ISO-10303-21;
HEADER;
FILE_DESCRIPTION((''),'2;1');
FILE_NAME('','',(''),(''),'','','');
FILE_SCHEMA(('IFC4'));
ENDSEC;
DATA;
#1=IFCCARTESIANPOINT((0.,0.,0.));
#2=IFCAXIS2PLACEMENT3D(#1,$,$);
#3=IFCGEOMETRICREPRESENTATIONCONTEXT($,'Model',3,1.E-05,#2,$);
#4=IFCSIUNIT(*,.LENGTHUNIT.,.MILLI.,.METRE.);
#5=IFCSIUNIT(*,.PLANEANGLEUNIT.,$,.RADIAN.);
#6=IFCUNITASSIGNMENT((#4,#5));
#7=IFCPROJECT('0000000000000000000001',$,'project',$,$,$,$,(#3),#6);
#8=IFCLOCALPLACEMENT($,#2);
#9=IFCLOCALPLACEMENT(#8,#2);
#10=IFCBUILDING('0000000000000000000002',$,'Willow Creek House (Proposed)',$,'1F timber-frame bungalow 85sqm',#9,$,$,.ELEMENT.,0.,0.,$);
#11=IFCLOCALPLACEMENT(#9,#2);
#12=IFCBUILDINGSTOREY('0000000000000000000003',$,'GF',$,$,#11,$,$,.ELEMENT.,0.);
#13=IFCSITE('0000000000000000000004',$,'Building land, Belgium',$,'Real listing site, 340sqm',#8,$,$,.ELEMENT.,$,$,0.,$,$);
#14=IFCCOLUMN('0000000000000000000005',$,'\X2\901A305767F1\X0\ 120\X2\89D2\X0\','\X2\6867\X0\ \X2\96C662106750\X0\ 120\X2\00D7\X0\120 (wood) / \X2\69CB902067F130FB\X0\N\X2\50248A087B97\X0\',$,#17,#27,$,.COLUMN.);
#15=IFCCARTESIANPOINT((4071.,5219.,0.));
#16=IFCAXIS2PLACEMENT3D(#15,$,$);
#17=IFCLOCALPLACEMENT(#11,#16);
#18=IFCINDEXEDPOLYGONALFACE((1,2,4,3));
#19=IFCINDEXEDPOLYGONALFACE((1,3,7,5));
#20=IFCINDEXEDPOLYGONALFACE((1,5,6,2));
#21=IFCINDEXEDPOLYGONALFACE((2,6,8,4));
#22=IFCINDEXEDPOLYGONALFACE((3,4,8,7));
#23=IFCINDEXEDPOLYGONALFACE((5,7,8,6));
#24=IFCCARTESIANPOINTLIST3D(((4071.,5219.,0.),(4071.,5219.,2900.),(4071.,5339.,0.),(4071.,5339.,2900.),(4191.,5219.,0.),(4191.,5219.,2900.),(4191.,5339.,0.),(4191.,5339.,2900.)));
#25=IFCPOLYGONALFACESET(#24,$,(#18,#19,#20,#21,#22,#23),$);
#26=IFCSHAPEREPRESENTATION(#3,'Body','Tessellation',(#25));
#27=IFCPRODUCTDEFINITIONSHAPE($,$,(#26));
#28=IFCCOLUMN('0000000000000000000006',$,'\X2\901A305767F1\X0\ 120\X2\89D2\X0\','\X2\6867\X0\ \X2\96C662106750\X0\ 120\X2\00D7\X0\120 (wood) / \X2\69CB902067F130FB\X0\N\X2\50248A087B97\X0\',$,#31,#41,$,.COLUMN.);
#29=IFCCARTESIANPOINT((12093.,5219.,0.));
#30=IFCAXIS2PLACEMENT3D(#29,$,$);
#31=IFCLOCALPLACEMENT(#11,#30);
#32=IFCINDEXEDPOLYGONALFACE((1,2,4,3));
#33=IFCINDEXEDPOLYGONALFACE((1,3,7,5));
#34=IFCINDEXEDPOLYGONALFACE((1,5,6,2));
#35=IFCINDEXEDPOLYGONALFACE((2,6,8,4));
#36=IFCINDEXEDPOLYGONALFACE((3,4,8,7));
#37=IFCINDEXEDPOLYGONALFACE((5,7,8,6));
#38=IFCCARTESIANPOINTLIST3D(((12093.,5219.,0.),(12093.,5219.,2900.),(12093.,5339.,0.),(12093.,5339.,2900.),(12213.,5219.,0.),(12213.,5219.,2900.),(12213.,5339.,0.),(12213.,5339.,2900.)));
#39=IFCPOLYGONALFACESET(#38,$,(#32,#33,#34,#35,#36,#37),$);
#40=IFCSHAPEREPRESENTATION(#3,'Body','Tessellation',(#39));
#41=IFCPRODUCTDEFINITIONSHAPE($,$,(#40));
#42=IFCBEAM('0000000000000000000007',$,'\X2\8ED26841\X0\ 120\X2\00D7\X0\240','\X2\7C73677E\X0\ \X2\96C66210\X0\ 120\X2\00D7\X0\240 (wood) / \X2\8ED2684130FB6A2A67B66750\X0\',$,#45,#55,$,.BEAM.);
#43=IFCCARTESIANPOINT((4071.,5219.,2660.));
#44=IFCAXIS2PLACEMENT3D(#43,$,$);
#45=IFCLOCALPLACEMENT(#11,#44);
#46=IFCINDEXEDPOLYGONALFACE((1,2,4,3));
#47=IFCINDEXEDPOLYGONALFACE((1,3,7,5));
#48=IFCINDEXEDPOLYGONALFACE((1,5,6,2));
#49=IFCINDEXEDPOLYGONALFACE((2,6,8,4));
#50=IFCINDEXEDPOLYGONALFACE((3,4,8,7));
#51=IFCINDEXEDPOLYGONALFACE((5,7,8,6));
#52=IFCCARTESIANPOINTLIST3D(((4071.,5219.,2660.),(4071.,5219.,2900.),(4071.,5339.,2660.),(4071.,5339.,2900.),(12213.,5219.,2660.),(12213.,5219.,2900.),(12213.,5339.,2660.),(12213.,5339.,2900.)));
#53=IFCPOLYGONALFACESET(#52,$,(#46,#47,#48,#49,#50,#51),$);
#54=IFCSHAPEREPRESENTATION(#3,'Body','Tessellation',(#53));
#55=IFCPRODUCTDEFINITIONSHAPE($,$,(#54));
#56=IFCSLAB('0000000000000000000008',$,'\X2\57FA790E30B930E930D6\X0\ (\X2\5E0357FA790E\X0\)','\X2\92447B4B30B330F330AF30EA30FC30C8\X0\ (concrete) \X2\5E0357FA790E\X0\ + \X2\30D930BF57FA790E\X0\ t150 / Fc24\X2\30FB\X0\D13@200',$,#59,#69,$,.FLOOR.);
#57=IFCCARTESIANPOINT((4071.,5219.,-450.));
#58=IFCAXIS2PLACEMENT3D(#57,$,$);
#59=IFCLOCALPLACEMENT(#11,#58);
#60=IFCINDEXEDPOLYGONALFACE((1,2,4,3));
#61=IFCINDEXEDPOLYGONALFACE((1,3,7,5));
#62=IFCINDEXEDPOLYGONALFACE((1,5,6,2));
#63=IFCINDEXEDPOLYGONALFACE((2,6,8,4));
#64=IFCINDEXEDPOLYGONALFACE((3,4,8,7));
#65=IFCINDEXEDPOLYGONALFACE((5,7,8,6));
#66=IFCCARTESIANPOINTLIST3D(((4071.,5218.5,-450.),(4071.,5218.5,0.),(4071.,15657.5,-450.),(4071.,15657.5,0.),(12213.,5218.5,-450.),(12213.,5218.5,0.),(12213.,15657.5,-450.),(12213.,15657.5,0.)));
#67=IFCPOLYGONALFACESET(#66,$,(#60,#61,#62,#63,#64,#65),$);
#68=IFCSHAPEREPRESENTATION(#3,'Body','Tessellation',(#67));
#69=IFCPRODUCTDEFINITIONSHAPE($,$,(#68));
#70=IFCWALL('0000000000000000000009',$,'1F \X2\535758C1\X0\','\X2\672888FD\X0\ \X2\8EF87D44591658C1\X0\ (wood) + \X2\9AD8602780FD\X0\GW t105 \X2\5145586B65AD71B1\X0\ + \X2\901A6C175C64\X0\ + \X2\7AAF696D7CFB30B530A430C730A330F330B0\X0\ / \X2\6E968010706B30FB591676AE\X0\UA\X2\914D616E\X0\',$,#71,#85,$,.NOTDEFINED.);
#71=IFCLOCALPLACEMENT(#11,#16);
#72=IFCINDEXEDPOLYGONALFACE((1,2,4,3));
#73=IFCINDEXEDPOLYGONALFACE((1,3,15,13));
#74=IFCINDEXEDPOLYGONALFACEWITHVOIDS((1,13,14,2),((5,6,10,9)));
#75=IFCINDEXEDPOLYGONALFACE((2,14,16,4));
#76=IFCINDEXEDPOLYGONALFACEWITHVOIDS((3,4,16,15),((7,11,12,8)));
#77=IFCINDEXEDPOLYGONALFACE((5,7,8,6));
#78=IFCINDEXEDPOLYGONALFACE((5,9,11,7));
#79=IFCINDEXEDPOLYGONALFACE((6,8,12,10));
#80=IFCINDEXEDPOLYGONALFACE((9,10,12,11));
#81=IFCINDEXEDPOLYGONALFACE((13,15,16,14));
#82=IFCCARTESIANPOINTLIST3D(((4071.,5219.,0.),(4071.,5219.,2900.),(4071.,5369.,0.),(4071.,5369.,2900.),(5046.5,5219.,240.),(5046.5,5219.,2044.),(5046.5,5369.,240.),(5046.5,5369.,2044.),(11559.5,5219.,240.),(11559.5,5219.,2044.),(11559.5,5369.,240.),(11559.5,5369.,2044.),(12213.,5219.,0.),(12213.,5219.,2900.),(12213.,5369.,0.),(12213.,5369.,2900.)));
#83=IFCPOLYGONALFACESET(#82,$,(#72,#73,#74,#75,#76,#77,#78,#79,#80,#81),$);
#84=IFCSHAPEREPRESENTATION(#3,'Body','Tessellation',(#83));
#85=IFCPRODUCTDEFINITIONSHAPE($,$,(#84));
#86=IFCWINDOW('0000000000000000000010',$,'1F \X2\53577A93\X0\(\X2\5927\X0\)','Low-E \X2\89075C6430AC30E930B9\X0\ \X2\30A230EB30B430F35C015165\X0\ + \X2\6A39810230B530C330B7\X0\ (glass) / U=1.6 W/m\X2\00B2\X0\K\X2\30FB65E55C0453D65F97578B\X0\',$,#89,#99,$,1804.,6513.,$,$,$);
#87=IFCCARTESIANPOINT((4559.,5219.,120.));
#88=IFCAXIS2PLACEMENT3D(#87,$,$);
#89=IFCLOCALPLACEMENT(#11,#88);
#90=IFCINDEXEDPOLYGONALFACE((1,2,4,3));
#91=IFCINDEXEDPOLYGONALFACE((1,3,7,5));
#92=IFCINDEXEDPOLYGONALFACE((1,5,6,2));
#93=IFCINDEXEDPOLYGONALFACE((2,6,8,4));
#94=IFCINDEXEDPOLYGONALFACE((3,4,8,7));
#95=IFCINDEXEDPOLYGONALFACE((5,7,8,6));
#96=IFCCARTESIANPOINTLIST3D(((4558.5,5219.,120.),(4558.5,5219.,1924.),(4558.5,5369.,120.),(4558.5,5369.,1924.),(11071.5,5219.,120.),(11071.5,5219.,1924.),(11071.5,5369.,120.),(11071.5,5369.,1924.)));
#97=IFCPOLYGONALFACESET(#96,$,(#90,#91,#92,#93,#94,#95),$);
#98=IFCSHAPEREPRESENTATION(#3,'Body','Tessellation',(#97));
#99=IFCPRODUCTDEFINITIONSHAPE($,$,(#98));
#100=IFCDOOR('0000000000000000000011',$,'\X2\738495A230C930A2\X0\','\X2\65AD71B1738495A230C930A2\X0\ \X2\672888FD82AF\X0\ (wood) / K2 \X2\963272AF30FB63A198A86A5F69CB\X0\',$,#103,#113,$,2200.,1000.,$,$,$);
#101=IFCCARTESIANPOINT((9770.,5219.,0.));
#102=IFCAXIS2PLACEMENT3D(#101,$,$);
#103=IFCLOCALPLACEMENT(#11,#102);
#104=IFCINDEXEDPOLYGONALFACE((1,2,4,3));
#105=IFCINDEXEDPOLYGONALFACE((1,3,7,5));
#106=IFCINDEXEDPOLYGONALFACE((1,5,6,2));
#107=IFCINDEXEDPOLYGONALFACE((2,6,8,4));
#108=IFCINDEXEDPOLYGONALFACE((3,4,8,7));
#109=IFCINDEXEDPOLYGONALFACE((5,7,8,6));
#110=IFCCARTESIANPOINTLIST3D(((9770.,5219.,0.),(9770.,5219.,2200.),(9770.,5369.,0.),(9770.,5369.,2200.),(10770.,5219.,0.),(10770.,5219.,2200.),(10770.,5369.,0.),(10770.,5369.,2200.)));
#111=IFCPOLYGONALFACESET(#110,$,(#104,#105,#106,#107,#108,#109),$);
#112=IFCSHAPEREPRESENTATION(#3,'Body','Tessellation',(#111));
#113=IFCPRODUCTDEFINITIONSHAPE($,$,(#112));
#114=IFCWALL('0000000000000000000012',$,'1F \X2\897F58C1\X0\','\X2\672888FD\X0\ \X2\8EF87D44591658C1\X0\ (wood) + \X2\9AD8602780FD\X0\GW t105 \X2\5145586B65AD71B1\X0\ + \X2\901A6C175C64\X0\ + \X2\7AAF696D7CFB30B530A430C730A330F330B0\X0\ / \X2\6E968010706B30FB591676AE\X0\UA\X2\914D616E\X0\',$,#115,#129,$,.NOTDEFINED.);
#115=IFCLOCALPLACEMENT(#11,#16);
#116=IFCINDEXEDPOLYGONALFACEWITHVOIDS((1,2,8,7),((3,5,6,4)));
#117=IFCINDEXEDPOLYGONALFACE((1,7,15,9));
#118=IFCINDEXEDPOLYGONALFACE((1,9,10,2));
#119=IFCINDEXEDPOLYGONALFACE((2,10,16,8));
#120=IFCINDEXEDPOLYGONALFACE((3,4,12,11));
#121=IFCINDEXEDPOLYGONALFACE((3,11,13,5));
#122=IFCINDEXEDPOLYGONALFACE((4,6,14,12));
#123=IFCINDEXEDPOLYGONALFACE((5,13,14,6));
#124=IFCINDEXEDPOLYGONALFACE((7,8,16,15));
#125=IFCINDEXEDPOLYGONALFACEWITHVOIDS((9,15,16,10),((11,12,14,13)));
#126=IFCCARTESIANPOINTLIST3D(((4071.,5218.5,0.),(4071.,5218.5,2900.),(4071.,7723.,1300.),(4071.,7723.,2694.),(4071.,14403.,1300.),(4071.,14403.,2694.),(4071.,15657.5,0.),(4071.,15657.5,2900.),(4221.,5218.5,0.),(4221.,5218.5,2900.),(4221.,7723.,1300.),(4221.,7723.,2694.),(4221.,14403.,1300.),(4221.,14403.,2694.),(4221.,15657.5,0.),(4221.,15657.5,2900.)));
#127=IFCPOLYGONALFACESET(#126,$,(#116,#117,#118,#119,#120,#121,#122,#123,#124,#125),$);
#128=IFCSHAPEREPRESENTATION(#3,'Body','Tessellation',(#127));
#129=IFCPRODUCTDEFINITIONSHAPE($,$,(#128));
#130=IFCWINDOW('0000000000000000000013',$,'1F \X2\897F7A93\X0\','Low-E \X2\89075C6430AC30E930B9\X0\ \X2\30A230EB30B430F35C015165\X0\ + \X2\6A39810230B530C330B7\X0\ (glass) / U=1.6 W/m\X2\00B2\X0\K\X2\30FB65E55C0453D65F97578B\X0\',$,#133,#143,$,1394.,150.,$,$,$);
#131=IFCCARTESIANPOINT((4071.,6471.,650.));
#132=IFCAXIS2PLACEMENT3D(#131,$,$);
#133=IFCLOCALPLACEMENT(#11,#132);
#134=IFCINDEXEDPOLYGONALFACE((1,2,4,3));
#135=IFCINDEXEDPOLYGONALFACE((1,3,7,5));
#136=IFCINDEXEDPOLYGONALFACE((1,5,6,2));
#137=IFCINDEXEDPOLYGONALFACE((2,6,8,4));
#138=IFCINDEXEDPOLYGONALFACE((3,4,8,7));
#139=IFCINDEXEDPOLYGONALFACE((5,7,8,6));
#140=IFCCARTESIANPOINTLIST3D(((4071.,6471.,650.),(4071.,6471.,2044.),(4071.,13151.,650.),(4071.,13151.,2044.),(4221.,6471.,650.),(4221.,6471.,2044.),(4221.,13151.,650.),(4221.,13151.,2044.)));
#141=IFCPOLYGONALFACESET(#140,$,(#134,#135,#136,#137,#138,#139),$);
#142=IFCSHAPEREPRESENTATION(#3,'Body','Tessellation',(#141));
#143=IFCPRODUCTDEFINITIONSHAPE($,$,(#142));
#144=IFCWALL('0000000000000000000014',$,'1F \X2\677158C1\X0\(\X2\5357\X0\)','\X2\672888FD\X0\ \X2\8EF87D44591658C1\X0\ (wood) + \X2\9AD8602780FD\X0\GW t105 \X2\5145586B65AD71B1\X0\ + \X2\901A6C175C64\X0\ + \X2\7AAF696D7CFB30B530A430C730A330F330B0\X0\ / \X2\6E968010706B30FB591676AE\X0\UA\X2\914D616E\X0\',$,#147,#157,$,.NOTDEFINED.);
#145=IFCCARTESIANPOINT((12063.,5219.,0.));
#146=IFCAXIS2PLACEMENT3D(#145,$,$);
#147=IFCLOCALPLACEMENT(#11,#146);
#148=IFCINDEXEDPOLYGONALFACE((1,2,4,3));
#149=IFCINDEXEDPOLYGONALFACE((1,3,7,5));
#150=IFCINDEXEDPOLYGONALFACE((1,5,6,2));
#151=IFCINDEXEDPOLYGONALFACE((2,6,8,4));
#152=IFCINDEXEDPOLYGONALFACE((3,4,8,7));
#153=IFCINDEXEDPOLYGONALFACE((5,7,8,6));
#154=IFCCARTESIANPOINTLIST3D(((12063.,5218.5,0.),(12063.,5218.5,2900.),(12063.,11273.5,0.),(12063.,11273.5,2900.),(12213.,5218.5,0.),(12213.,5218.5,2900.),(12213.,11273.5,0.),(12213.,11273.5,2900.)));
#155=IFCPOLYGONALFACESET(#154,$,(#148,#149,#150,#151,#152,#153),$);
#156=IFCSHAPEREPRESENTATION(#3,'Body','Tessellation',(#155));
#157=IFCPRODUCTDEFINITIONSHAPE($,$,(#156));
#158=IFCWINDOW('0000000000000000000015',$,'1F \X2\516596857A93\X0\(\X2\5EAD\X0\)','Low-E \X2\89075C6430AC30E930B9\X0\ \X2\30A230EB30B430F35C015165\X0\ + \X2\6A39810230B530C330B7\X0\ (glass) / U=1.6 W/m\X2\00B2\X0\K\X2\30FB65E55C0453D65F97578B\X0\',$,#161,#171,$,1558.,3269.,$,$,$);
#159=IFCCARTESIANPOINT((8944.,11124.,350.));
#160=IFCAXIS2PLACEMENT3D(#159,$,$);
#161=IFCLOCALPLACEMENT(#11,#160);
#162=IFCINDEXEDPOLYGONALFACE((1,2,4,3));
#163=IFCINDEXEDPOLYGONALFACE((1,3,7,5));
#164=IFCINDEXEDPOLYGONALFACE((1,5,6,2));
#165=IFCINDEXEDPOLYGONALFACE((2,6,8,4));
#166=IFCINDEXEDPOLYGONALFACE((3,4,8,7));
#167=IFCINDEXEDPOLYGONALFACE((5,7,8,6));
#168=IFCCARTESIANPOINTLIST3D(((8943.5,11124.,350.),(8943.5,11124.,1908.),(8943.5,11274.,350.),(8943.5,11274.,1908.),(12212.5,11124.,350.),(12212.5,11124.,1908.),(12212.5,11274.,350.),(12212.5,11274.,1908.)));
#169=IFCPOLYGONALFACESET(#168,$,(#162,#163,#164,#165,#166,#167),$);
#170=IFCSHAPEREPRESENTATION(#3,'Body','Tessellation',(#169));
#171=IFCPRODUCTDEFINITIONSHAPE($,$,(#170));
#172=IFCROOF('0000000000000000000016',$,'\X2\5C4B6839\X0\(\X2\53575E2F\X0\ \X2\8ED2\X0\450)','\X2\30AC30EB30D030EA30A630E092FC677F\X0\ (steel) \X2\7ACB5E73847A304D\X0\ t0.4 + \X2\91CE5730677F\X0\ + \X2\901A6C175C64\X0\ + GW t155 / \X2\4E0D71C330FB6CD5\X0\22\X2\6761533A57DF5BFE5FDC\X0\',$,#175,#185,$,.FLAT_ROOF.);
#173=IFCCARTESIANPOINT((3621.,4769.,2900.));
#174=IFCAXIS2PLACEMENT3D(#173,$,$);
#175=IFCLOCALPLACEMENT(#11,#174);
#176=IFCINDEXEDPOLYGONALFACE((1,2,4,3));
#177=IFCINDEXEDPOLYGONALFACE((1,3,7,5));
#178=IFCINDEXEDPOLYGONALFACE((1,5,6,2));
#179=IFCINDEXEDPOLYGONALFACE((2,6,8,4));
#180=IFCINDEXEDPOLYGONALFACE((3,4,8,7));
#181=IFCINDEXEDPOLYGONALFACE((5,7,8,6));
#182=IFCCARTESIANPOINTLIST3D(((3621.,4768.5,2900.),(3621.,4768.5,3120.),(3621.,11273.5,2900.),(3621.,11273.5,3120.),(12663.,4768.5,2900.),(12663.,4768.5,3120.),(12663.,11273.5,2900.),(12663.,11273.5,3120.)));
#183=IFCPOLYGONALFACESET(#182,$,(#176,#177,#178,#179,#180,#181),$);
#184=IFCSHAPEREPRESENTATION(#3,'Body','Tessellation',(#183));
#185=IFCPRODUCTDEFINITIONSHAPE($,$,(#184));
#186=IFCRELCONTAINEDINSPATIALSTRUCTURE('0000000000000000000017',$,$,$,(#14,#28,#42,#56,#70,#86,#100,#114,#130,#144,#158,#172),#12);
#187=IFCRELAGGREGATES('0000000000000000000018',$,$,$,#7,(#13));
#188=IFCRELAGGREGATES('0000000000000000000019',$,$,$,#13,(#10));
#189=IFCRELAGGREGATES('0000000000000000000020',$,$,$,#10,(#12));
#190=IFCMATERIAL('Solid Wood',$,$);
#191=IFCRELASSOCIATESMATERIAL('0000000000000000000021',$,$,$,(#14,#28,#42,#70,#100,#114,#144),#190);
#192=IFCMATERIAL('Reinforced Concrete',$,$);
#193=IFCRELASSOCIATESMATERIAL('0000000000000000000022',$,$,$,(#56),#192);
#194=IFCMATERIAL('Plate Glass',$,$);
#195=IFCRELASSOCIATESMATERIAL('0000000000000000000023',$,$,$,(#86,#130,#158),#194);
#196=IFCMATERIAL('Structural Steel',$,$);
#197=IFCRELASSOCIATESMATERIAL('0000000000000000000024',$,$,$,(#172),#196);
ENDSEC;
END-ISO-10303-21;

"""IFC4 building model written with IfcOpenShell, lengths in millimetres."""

from ifc_helpers import new_model, si_unit, frame, frame_2d, origin, place, context, project, spatial, rectangle, extrude, material, element, fill, save


model = new_model("IFC4")

# Units and contexts
model_context = context("Model", 3, precision=1e-05, world=origin())
ifc_project = project(units=[si_unit("LENGTHUNIT", "METRE", prefix="MILLI"), si_unit("PLANEANGLEUNIT", "RADIAN")], contexts=[model_context])

# Site, building, storey
site_placement = place(None, origin())
site = spatial("IfcSite", under=ifc_project, at=site_placement, Name="Building land, Belgium", ObjectType="Real listing site, 340sqm", CompositionType="ELEMENT", RefElevation=0.0)
building_placement = place(site_placement, origin())
building = spatial("IfcBuilding", under=site, at=building_placement, Name="Willow Creek House (Proposed)", ObjectType="1F timber-frame bungalow 85sqm", CompositionType="ELEMENT", ElevationOfRefHeight=0.0, ElevationOfTerrain=0.0)
storey_placement = place(building_placement, origin())
storey = spatial("IfcBuildingStorey", under=building, at=storey_placement, Name="GF", CompositionType="ELEMENT", Elevation=0.0)

# Columns
ifc_material_1 = material(Name="Solid Wood")
column_1_placement = place(storey_placement, frame((4071.0, 5219.0, 0.0)))
element("IfcColumn", 1, at=column_1_placement, inside=storey, material=ifc_material_1, Name="通し柱 120角", Description="桧 集成材 120×120 (wood) / 構造柱・N値計算", PredefinedType="COLUMN", context=model_context, shape_type="SweptSolid", body=[
    extrude(rectangle(XDim=120.0, YDim=120.0, at=frame_2d((60.0, 60.0))), frame((4071.0, 5219.0, 0.0)), (0.0, 0.0, 1.0), 2900.0),
])
column_2_placement = place(storey_placement, frame((12093.0, 5219.0, 0.0)))
element("IfcColumn", 2, at=column_2_placement, inside=storey, material=ifc_material_1, Name="通し柱 120角", Description="桧 集成材 120×120 (wood) / 構造柱・N値計算", PredefinedType="COLUMN", context=model_context, shape_type="SweptSolid", body=[
    extrude(rectangle(XDim=120.0, YDim=120.0, at=frame_2d((60.0, 60.0))), frame((12093.0, 5219.0, 0.0)), (0.0, 0.0, 1.0), 2900.0),
])

# Beam
beam_1_placement = place(storey_placement, frame((4071.0, 5219.0, 2660.0)))
element("IfcBeam", 3, at=beam_1_placement, inside=storey, material=ifc_material_1, Name="軒桁 120×240", Description="米松 集成 120×240 (wood) / 軒桁・横架材", PredefinedType="BEAM", context=model_context, shape_type="SweptSolid", body=[
    extrude(rectangle(XDim=8142.0, YDim=120.0, at=frame_2d((4071.0, 60.0))), frame((4071.0, 5219.0, 2660.0)), (0.0, 0.0, 1.0), 240.0),
])

# Slab
ifc_material_2 = material(Name="Reinforced Concrete")
slab_1_placement = place(storey_placement, frame((4071.0, 5219.0, -450.0)))
element("IfcSlab", 4, at=slab_1_placement, inside=storey, material=ifc_material_2, Name="基礎スラブ (布基礎)", Description="鉄筋コンクリート (concrete) 布基礎 + ベタ基礎 t150 / Fc24・D13@200", PredefinedType="FLOOR", context=model_context, shape_type="SweptSolid", body=[
    extrude(rectangle(XDim=8142.0, YDim=10439.0, at=frame_2d((4071.0, 5219.0))), frame((4071.0, 5219.0, -450.0)), (0.0, 0.0, 1.0), 450.0),
])

# Wall, openings, window, door
wall_1_placement = place(storey_placement, frame((4071.0, 5219.0, 0.0)))
wall_1 = element("IfcWall", 5, at=wall_1_placement, inside=storey, material=ifc_material_1, Name="1F 南壁", Description="木製 軸組外壁 (wood) + 高性能GW t105 充填断熱 + 通気層 + 窯業系サイディング / 準耐火・外皮UA配慮", PredefinedType="NOTDEFINED", context=model_context, shape_type="SweptSolid", body=[
    extrude(rectangle(XDim=8142.0, YDim=150.0, at=frame_2d((4071.0, 75.0))), frame((4071.0, 5219.0, 0.0)), (0.0, 0.0, 1.0), 2900.0),
])
opening_1_placement = place(storey_placement, frame((4559.0, 5219.0, 120.0)))
opening_1 = element("IfcOpeningElement", 6, at=opening_1_placement, cuts=wall_1, PredefinedType="NOTDEFINED", context=model_context, shape_type="SweptSolid", body=[
    extrude(rectangle(XDim=6513.0, YDim=150.0, at=frame_2d((3256.0, 75.0))), frame((4559.0, 5219.0, 120.0)), (0.0, 0.0, 1.0), 1804.0),
])
opening_2_placement = place(storey_placement, frame((9770.0, 5219.0, 0.0)))
opening_2 = element("IfcOpeningElement", 7, at=opening_2_placement, cuts=wall_1, PredefinedType="NOTDEFINED", context=model_context, shape_type="SweptSolid", body=[
    extrude(rectangle(XDim=1000.0, YDim=150.0, at=frame_2d((500.0, 75.0))), frame((9770.0, 5219.0, 0.0)), (0.0, 0.0, 1.0), 2200.0),
])
ifc_material_3 = material(Name="Plate Glass")
window_1_placement = place(storey_placement, frame((4559.0, 5219.0, 120.0)))
window_1 = element("IfcWindow", 8, at=window_1_placement, inside=storey, material=ifc_material_3, Name="1F 南窓(大)", Description="Low-E 複層ガラス アルゴン封入 + 樹脂サッシ (glass) / U=1.6 W/m²K・日射取得型", OverallHeight=1804.0, OverallWidth=6513.0, context=model_context, shape_type="SweptSolid", body=[
    extrude(rectangle(XDim=6513.0, YDim=150.0, at=frame_2d((3256.0, 75.0))), frame((4559.0, 5219.0, 120.0)), (0.0, 0.0, 1.0), 1804.0),
])
fill(opening_1, window_1)
door_1_placement = place(storey_placement, frame((9770.0, 5219.0, 0.0)))
door_1 = element("IfcDoor", 9, at=door_1_placement, inside=storey, material=ifc_material_1, Name="玄関ドア", Description="断熱玄関ドア 木製芯 (wood) / K2 防犯・採風機構", OverallHeight=2200.0, OverallWidth=1000.0, context=model_context, shape_type="SweptSolid", body=[
    extrude(rectangle(XDim=1000.0, YDim=150.0, at=frame_2d((500.0, 75.0))), frame((9770.0, 5219.0, 0.0)), (0.0, 0.0, 1.0), 2200.0),
])
fill(opening_2, door_1)

# Walls, openings, windows
wall_2_placement = place(storey_placement, frame((4071.0, 5219.0, 0.0)))
wall_2 = element("IfcWall", 10, at=wall_2_placement, inside=storey, material=ifc_material_1, Name="1F 西壁", Description="木製 軸組外壁 (wood) + 高性能GW t105 充填断熱 + 通気層 + 窯業系サイディング / 準耐火・外皮UA配慮", PredefinedType="NOTDEFINED", context=model_context, shape_type="SweptSolid", body=[
    extrude(rectangle(XDim=150.0, YDim=10439.0, at=frame_2d((75.0, 5219.0))), frame((4071.0, 5219.0, 0.0)), (0.0, 0.0, 1.0), 2900.0),
])
opening_3_placement = place(storey_placement, frame((4071.0, 6471.0, 650.0)))
opening_3 = element("IfcOpeningElement", 11, at=opening_3_placement, cuts=wall_2, PredefinedType="NOTDEFINED", context=model_context, shape_type="SweptSolid", body=[
    extrude(rectangle(XDim=150.0, YDim=6680.0, at=frame_2d((75.0, 3340.0))), frame((4071.0, 6471.0, 650.0)), (0.0, 0.0, 1.0), 1394.0),
])
window_2_placement = place(storey_placement, frame((4071.0, 6471.0, 650.0)))
window_2 = element("IfcWindow", 12, at=window_2_placement, inside=storey, material=ifc_material_3, Name="1F 西窓", Description="Low-E 複層ガラス アルゴン封入 + 樹脂サッシ (glass) / U=1.6 W/m²K・日射取得型", OverallHeight=1394.0, OverallWidth=150.0, context=model_context, shape_type="SweptSolid", body=[
    extrude(rectangle(XDim=150.0, YDim=6680.0, at=frame_2d((75.0, 3340.0))), frame((4071.0, 6471.0, 650.0)), (0.0, 0.0, 1.0), 1394.0),
])
fill(opening_3, window_2)
wall_3_placement = place(storey_placement, frame((12063.0, 5219.0, 0.0)))
wall_3 = element("IfcWall", 13, at=wall_3_placement, inside=storey, material=ifc_material_1, Name="1F 東壁(南)", Description="木製 軸組外壁 (wood) + 高性能GW t105 充填断熱 + 通気層 + 窯業系サイディング / 準耐火・外皮UA配慮", PredefinedType="NOTDEFINED", context=model_context, shape_type="SweptSolid", body=[
    extrude(rectangle(XDim=150.0, YDim=6055.0, at=frame_2d((75.0, 3027.0))), frame((12063.0, 5219.0, 0.0)), (0.0, 0.0, 1.0), 2900.0),
])
opening_4_placement = place(storey_placement, frame((8944.0, 11124.0, 350.0)))
opening_4 = element("IfcOpeningElement", 14, at=opening_4_placement, cuts=wall_3, PredefinedType="NOTDEFINED", context=model_context, shape_type="SweptSolid", body=[
    extrude(rectangle(XDim=3269.0, YDim=150.0, at=frame_2d((1634.0, 75.0))), frame((8944.0, 11124.0, 350.0)), (0.0, 0.0, 1.0), 1558.0),
])
window_3_placement = place(storey_placement, frame((8944.0, 11124.0, 350.0)))
window_3 = element("IfcWindow", 15, at=window_3_placement, inside=storey, material=ifc_material_3, Name="1F 入隅窓(庭)", Description="Low-E 複層ガラス アルゴン封入 + 樹脂サッシ (glass) / U=1.6 W/m²K・日射取得型", OverallHeight=1558.0, OverallWidth=3269.0, context=model_context, shape_type="SweptSolid", body=[
    extrude(rectangle(XDim=3269.0, YDim=150.0, at=frame_2d((1634.0, 75.0))), frame((8944.0, 11124.0, 350.0)), (0.0, 0.0, 1.0), 1558.0),
])
fill(opening_4, window_3)

# Roof
ifc_material_4 = material(Name="Structural Steel")
roof_placement = place(storey_placement, frame((3621.0, 4769.0, 2900.0)))
element("IfcRoof", 16, at=roof_placement, inside=storey, material=ifc_material_4, Name="屋根(南帯 軒450)", Description="ガルバリウム鋼板 (steel) 立平葺き t0.4 + 野地板 + 通気層 + GW t155 / 不燃・法22条区域対応", PredefinedType="FLAT_ROOF", context=model_context, shape_type="SweptSolid", body=[
    extrude(rectangle(XDim=9042.0, YDim=6505.0, at=frame_2d((4521.0, 3252.0))), frame((3621.0, 4769.0, 2900.0)), (0.0, 0.0, 1.0), 220.0),
])

save(model, "model.ifc")
